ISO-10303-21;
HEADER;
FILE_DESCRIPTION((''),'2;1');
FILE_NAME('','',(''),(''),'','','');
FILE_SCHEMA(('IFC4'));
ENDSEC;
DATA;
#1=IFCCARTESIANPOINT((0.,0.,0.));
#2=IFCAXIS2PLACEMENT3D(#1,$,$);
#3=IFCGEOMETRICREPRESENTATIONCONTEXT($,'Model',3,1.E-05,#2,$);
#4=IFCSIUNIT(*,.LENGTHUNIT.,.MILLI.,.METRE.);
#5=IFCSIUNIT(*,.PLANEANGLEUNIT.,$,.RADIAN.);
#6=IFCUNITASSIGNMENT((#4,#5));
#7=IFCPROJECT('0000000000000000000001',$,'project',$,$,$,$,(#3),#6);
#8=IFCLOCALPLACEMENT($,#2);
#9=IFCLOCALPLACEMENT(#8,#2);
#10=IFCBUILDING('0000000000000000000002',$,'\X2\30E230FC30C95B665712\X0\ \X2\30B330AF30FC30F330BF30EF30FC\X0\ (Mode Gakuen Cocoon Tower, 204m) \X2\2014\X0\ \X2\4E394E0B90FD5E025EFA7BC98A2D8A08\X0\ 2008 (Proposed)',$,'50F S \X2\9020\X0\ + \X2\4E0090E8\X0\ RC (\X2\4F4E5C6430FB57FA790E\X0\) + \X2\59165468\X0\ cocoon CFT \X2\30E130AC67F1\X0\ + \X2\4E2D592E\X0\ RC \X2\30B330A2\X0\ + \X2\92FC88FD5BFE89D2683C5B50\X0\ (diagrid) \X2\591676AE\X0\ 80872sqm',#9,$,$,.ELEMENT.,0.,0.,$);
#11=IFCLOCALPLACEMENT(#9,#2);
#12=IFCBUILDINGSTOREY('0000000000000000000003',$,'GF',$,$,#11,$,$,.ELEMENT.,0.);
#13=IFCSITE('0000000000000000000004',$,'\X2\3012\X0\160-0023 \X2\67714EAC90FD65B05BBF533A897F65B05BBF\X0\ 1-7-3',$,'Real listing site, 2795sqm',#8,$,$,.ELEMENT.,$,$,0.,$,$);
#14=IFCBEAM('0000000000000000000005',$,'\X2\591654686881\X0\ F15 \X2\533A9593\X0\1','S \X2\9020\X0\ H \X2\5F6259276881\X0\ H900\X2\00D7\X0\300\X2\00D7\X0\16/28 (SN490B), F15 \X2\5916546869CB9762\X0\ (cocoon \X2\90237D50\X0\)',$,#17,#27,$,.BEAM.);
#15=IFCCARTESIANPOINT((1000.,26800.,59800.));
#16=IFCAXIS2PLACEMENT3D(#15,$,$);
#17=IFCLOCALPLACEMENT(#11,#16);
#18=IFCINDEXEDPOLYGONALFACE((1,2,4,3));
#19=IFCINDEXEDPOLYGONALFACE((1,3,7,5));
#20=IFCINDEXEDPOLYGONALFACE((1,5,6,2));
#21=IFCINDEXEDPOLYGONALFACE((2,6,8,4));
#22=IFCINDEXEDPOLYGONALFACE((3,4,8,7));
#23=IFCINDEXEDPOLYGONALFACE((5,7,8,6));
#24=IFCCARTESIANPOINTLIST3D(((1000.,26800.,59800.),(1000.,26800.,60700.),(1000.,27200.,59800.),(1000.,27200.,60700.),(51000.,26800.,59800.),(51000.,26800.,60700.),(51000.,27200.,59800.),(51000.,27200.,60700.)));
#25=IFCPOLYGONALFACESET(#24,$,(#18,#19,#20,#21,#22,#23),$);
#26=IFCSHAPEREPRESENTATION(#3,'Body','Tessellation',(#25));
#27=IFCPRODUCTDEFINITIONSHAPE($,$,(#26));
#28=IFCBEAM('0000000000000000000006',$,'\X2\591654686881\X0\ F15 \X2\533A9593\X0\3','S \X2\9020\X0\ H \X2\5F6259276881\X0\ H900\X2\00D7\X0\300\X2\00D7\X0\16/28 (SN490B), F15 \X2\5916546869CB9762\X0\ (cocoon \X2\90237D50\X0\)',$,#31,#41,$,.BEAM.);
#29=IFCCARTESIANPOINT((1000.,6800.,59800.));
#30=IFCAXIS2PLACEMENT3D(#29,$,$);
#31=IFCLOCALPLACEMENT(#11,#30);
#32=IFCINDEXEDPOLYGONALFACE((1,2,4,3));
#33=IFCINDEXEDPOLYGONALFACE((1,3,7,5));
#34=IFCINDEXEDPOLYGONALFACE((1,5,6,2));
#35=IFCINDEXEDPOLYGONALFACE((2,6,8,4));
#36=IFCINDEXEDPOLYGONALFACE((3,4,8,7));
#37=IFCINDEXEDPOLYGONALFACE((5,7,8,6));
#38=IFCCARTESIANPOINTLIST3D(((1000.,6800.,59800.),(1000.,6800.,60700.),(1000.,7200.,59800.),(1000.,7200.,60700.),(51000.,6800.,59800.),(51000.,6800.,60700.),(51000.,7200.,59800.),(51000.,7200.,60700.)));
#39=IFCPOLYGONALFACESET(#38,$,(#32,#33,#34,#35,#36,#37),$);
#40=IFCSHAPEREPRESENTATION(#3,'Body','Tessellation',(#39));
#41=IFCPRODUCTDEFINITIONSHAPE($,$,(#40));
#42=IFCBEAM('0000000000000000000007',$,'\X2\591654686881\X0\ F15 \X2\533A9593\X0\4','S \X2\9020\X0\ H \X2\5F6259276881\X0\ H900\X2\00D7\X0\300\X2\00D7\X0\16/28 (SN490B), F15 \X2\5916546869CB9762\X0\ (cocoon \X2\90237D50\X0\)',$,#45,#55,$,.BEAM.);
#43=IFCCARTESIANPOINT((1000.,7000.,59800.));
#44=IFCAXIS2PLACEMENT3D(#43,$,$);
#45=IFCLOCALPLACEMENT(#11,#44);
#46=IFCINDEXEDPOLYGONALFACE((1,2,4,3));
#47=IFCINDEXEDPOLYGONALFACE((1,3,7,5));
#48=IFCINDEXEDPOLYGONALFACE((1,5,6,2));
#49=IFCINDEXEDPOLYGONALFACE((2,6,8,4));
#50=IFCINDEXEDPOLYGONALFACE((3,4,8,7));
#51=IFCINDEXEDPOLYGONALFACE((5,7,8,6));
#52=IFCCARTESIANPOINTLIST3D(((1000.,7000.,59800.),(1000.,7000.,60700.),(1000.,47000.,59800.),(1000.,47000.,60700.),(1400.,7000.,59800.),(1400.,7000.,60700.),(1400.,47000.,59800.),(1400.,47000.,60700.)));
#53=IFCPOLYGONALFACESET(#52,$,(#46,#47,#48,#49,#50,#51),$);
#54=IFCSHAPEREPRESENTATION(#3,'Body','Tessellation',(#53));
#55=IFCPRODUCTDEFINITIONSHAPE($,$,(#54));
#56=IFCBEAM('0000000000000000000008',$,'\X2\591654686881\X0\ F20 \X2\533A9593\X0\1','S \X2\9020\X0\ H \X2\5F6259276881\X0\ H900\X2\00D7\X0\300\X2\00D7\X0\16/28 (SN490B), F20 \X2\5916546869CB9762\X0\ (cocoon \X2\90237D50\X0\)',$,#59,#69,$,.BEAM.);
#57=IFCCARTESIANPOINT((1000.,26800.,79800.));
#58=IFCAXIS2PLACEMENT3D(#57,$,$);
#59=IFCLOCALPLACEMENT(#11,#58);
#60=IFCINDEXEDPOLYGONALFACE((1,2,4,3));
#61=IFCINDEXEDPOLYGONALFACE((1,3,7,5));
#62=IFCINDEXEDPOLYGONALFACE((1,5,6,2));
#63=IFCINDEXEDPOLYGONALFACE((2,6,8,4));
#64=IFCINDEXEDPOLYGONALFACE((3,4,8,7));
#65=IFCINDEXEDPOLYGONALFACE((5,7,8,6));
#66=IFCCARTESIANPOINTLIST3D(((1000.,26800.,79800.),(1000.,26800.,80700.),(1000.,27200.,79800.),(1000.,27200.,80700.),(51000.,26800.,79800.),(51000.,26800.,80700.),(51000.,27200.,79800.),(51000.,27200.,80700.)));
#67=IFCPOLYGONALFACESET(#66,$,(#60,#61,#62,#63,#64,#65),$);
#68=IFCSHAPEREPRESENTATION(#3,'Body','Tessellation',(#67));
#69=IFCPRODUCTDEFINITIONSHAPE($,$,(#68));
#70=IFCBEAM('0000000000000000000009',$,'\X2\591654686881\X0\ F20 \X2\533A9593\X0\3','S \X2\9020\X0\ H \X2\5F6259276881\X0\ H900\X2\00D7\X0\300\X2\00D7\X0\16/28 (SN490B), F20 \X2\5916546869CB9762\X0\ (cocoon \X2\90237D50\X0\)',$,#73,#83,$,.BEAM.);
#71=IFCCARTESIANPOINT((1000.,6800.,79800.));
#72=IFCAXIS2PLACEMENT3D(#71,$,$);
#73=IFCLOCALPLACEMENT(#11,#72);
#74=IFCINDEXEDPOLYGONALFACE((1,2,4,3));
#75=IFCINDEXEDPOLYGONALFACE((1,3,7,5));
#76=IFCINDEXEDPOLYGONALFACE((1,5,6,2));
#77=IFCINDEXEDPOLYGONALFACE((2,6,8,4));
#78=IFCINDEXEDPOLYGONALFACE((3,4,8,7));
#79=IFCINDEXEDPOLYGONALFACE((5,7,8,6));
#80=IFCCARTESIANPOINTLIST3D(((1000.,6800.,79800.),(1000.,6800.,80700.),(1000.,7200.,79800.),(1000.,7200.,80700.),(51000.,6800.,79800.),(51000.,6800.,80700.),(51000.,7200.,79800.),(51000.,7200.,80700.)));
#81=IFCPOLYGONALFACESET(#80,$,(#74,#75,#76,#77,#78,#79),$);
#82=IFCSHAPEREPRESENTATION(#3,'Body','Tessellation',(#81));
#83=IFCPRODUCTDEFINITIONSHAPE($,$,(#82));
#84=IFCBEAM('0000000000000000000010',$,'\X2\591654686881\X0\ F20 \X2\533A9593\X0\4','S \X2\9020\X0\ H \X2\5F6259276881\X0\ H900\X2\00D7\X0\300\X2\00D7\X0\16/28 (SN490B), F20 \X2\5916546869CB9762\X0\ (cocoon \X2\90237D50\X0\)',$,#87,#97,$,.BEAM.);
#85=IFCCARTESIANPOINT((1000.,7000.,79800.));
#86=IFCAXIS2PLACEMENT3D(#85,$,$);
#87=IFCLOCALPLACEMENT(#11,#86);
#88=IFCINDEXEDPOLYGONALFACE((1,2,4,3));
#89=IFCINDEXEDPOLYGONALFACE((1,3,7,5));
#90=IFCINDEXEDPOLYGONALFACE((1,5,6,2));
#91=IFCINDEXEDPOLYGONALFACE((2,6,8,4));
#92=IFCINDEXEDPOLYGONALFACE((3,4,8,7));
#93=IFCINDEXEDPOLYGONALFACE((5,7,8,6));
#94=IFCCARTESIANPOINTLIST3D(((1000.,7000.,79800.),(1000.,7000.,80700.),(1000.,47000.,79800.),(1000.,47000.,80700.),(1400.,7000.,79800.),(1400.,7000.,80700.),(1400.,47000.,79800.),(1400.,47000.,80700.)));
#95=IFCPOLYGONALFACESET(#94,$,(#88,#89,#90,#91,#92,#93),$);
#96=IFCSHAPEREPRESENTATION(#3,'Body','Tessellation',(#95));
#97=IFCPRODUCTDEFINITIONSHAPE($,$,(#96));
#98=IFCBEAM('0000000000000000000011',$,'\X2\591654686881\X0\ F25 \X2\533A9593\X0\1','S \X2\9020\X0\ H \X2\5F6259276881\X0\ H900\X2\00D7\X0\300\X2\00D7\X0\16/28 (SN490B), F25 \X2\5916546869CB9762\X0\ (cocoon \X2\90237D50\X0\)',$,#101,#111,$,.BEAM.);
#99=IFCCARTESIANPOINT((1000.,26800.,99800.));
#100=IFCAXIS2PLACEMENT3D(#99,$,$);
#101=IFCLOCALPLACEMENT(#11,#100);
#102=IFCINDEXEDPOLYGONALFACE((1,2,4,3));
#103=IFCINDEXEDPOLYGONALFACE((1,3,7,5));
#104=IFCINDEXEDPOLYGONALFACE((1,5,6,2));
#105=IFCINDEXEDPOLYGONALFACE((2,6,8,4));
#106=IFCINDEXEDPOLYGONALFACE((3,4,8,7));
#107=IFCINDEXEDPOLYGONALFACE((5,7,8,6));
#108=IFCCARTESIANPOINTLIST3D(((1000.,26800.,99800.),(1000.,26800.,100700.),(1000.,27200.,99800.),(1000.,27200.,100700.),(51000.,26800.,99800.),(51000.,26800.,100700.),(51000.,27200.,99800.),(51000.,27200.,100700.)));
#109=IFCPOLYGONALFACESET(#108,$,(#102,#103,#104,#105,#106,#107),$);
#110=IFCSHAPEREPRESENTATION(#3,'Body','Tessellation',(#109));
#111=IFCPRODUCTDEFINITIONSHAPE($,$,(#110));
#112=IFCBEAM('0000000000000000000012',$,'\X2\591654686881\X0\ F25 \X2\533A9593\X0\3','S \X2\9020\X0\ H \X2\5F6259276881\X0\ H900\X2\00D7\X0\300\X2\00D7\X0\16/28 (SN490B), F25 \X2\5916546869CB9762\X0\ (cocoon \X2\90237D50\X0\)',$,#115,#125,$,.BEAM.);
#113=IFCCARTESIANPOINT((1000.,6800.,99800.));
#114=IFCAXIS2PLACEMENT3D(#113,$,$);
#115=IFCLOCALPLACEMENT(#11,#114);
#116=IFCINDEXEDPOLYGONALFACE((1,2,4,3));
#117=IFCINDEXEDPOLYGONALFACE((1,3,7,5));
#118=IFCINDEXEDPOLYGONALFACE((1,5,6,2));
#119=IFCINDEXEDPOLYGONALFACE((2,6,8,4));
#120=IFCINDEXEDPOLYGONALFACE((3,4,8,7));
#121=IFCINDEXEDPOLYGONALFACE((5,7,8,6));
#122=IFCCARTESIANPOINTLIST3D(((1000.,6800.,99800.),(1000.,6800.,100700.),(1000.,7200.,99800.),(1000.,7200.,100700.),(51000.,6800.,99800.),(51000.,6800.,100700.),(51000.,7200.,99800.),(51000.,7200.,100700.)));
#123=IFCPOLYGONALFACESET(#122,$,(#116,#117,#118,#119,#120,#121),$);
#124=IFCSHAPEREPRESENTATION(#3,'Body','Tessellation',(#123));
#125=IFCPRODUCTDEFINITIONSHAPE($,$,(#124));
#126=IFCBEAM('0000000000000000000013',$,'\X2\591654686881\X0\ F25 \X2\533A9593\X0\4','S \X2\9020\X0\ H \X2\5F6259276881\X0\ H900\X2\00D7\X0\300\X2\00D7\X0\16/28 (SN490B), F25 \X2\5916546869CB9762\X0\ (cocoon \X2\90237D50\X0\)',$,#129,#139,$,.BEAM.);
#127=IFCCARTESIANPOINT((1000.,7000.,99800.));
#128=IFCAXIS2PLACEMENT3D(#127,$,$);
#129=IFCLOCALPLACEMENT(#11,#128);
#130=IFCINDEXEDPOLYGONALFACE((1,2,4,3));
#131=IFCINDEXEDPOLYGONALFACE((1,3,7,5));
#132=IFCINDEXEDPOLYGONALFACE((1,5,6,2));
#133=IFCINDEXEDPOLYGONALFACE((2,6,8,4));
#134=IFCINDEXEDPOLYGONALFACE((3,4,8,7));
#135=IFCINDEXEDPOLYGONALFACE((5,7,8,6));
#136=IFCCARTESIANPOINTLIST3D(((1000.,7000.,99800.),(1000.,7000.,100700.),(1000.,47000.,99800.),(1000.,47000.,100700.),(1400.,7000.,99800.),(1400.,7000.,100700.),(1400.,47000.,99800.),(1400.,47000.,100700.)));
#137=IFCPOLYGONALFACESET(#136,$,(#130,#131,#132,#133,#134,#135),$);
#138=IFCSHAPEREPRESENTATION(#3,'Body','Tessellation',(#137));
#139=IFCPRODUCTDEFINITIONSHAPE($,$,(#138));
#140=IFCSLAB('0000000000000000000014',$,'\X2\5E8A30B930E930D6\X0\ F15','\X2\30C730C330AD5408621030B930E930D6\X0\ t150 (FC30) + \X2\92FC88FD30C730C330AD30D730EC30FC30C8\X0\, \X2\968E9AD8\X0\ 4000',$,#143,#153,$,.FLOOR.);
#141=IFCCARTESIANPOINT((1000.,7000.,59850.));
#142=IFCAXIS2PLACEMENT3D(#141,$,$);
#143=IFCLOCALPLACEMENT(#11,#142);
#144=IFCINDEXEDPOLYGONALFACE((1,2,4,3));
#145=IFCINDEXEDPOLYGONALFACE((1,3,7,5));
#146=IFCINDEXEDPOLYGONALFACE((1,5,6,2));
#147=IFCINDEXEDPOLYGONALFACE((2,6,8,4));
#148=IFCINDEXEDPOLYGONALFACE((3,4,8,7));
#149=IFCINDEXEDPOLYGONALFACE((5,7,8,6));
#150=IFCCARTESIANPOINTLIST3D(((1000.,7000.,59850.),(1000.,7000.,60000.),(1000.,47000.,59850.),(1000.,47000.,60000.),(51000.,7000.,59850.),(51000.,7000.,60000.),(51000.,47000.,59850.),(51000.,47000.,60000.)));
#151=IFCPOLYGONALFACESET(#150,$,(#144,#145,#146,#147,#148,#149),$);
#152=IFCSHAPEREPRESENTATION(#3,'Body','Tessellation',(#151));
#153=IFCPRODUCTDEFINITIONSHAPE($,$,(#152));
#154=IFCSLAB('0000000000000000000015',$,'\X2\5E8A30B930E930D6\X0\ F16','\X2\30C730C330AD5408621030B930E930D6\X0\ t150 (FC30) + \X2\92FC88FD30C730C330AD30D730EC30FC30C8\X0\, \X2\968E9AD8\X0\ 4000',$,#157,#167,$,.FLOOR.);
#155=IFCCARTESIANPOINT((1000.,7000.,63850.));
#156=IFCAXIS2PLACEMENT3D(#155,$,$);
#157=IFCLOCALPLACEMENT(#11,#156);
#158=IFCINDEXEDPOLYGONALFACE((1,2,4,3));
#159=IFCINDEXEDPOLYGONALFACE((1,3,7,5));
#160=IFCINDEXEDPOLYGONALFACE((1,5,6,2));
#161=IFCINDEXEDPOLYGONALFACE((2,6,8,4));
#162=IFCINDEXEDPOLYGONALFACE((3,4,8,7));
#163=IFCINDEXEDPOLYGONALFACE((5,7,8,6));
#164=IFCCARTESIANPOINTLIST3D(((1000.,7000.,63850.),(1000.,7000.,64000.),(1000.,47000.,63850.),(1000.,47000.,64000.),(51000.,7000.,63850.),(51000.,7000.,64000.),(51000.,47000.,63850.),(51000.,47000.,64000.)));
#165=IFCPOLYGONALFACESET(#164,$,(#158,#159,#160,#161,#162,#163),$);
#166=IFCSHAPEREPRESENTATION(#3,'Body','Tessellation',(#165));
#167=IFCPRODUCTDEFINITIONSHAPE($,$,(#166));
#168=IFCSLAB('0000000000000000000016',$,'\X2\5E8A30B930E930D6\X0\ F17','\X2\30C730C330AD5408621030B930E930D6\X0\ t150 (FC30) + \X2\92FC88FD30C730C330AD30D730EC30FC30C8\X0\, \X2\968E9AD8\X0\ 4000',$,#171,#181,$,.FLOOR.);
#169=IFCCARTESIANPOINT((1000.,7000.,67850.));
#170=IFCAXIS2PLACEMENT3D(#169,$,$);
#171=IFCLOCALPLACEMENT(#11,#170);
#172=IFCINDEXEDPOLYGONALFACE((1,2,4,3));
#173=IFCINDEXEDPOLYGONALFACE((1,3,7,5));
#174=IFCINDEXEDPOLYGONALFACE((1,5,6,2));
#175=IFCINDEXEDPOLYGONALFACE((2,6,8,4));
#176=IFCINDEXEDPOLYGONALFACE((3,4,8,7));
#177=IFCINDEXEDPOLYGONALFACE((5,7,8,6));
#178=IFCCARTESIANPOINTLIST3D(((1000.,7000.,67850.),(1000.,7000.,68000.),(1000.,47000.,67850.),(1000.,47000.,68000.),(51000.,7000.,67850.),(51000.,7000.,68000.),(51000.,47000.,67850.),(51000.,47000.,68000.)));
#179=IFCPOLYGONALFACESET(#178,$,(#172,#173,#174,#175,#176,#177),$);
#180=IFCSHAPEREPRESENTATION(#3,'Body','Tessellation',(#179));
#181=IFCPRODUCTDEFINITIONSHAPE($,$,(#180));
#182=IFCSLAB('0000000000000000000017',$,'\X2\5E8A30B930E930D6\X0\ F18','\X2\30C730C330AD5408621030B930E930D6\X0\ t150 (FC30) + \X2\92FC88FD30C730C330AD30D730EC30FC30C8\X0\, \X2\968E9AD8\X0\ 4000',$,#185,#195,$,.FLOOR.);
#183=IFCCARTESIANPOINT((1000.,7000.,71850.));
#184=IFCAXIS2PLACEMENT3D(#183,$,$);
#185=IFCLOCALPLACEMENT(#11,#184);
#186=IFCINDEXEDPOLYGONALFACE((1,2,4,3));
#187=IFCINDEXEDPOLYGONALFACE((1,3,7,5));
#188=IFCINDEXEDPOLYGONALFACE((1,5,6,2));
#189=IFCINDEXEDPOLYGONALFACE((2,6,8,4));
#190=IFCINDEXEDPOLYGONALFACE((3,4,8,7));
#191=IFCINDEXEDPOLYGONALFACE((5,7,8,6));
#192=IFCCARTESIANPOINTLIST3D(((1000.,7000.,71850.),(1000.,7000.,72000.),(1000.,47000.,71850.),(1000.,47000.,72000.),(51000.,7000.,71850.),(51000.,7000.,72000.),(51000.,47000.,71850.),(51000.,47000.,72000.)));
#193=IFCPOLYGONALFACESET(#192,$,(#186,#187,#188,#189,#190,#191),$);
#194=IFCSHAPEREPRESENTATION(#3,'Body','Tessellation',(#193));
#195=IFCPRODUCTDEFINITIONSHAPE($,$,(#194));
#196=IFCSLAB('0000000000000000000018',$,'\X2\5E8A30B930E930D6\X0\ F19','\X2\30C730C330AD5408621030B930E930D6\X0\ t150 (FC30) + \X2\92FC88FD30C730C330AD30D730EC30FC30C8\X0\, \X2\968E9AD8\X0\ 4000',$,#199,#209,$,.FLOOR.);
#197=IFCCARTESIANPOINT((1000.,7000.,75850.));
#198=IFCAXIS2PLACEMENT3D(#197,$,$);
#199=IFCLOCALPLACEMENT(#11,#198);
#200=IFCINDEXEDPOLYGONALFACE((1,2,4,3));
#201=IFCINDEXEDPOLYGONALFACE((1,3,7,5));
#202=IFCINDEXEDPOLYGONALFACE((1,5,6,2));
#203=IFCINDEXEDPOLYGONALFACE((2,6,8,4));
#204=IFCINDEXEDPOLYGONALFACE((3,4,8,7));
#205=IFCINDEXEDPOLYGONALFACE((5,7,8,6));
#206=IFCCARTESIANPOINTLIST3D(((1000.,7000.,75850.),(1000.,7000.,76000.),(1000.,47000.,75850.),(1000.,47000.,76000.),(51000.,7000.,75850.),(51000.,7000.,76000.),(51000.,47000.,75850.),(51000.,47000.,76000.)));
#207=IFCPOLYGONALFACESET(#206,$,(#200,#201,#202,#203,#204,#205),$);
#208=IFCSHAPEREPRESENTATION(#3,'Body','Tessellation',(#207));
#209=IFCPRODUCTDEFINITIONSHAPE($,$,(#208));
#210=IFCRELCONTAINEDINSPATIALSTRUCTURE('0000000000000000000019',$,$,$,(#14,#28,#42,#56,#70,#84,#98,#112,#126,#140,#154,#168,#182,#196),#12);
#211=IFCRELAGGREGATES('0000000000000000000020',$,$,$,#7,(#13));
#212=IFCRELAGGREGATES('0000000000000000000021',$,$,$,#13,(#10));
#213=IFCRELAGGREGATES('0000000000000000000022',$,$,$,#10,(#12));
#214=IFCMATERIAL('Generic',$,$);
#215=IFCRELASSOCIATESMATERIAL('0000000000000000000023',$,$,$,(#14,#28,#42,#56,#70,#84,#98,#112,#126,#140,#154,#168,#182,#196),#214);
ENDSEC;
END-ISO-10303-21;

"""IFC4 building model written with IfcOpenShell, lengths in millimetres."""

from ifc_helpers import new_model, si_unit, frame, frame_2d, origin, place, context, project, spatial, rectangle, extrude, material, element, save


model = new_model("IFC4")

# Units and contexts
model_context = context("Model", 3, precision=1e-05, world=origin())
ifc_project = project(units=[si_unit("LENGTHUNIT", "METRE", prefix="MILLI"), si_unit("PLANEANGLEUNIT", "RADIAN")], contexts=[model_context])

# Site, building, storey
site_placement = place(None, origin())
site = spatial("IfcSite", under=ifc_project, at=site_placement, Name="〒160-0023 東京都新宿区西新宿 1-7-3", ObjectType="Real listing site, 2795sqm", CompositionType="ELEMENT", RefElevation=0.0)
building_placement = place(site_placement, origin())
building = spatial("IfcBuilding", under=site, at=building_placement, Name="モード学園 コクーンタワー (Mode Gakuen Cocoon Tower, 204m) — 丹下都市建築設計 2008 (Proposed)", ObjectType="50F S 造 + 一部 RC (低層・基礎) + 外周 cocoon CFT メガ柱 + 中央 RC コア + 鋼製対角格子 (diagrid) 外皮 80872sqm", CompositionType="ELEMENT", ElevationOfRefHeight=0.0, ElevationOfTerrain=0.0)
storey_placement = place(building_placement, origin())
storey = spatial("IfcBuildingStorey", under=building, at=storey_placement, Name="GF", CompositionType="ELEMENT", Elevation=0.0)

# Beams
ifc_material_1 = material(Name="Generic")
beam_1_placement = place(storey_placement, frame((1000.0, 26800.0, 59800.0)))
element("IfcBeam", 1, at=beam_1_placement, inside=storey, material=ifc_material_1, Name="外周梁 F15 区間1", Description="S 造 H 形大梁 H900×300×16/28 (SN490B), F15 外周構面 (cocoon 連結)", PredefinedType="BEAM", context=model_context, shape_type="SweptSolid", body=[
    extrude(rectangle(XDim=50000.0, YDim=400.0, at=frame_2d((25000.0, 200.0))), frame((1000.0, 26800.0, 59800.0)), (0.0, 0.0, 1.0), 900.0),
])
beam_2_placement = place(storey_placement, frame((1000.0, 6800.0, 59800.0)))
element("IfcBeam", 2, at=beam_2_placement, inside=storey, material=ifc_material_1, Name="外周梁 F15 区間3", Description="S 造 H 形大梁 H900×300×16/28 (SN490B), F15 外周構面 (cocoon 連結)", PredefinedType="BEAM", context=model_context, shape_type="SweptSolid", body=[
    extrude(rectangle(XDim=50000.0, YDim=400.0, at=frame_2d((25000.0, 200.0))), frame((1000.0, 6800.0, 59800.0)), (0.0, 0.0, 1.0), 900.0),
])
beam_3_placement = place(storey_placement, frame((1000.0, 7000.0, 59800.0)))
element("IfcBeam", 3, at=beam_3_placement, inside=storey, material=ifc_material_1, Name="外周梁 F15 区間4", Description="S 造 H 形大梁 H900×300×16/28 (SN490B), F15 外周構面 (cocoon 連結)", PredefinedType="BEAM", context=model_context, shape_type="SweptSolid", body=[
    extrude(rectangle(XDim=400.0, YDim=40000.0, at=frame_2d((200.0, 20000.0))), frame((1000.0, 7000.0, 59800.0)), (0.0, 0.0, 1.0), 900.0),
])
beam_4_placement = place(storey_placement, frame((1000.0, 26800.0, 79800.0)))
element("IfcBeam", 4, at=beam_4_placement, inside=storey, material=ifc_material_1, Name="外周梁 F20 区間1", Description="S 造 H 形大梁 H900×300×16/28 (SN490B), F20 外周構面 (cocoon 連結)", PredefinedType="BEAM", context=model_context, shape_type="SweptSolid", body=[
    extrude(rectangle(XDim=50000.0, YDim=400.0, at=frame_2d((25000.0, 200.0))), frame((1000.0, 26800.0, 79800.0)), (0.0, 0.0, 1.0), 900.0),
])
beam_5_placement = place(storey_placement, frame((1000.0, 6800.0, 79800.0)))
element("IfcBeam", 5, at=beam_5_placement, inside=storey, material=ifc_material_1, Name="外周梁 F20 区間3", Description="S 造 H 形大梁 H900×300×16/28 (SN490B), F20 外周構面 (cocoon 連結)", PredefinedType="BEAM", context=model_context, shape_type="SweptSolid", body=[
    extrude(rectangle(XDim=50000.0, YDim=400.0, at=frame_2d((25000.0, 200.0))), frame((1000.0, 6800.0, 79800.0)), (0.0, 0.0, 1.0), 900.0),
])
beam_6_placement = place(storey_placement, frame((1000.0, 7000.0, 79800.0)))
element("IfcBeam", 6, at=beam_6_placement, inside=storey, material=ifc_material_1, Name="外周梁 F20 区間4", Description="S 造 H 形大梁 H900×300×16/28 (SN490B), F20 外周構面 (cocoon 連結)", PredefinedType="BEAM", context=model_context, shape_type="SweptSolid", body=[
    extrude(rectangle(XDim=400.0, YDim=40000.0, at=frame_2d((200.0, 20000.0))), frame((1000.0, 7000.0, 79800.0)), (0.0, 0.0, 1.0), 900.0),
])
beam_7_placement = place(storey_placement, frame((1000.0, 26800.0, 99800.0)))
element("IfcBeam", 7, at=beam_7_placement, inside=storey, material=ifc_material_1, Name="外周梁 F25 区間1", Description="S 造 H 形大梁 H900×300×16/28 (SN490B), F25 外周構面 (cocoon 連結)", PredefinedType="BEAM", context=model_context, shape_type="SweptSolid", body=[
    extrude(rectangle(XDim=50000.0, YDim=400.0, at=frame_2d((25000.0, 200.0))), frame((1000.0, 26800.0, 99800.0)), (0.0, 0.0, 1.0), 900.0),
])
beam_8_placement = place(storey_placement, frame((1000.0, 6800.0, 99800.0)))
element("IfcBeam", 8, at=beam_8_placement, inside=storey, material=ifc_material_1, Name="外周梁 F25 区間3", Description="S 造 H 形大梁 H900×300×16/28 (SN490B), F25 外周構面 (cocoon 連結)", PredefinedType="BEAM", context=model_context, shape_type="SweptSolid", body=[
    extrude(rectangle(XDim=50000.0, YDim=400.0, at=frame_2d((25000.0, 200.0))), frame((1000.0, 6800.0, 99800.0)), (0.0, 0.0, 1.0), 900.0),
])
beam_9_placement = place(storey_placement, frame((1000.0, 7000.0, 99800.0)))
element("IfcBeam", 9, at=beam_9_placement, inside=storey, material=ifc_material_1, Name="外周梁 F25 区間4", Description="S 造 H 形大梁 H900×300×16/28 (SN490B), F25 外周構面 (cocoon 連結)", PredefinedType="BEAM", context=model_context, shape_type="SweptSolid", body=[
    extrude(rectangle(XDim=400.0, YDim=40000.0, at=frame_2d((200.0, 20000.0))), frame((1000.0, 7000.0, 99800.0)), (0.0, 0.0, 1.0), 900.0),
])

# Slabs
slab_1_placement = place(storey_placement, frame((1000.0, 7000.0, 59850.0)))
element("IfcSlab", 10, at=slab_1_placement, inside=storey, material=ifc_material_1, Name="床スラブ F15", Description="デッキ合成スラブ t150 (FC30) + 鋼製デッキプレート, 階高 4000", PredefinedType="FLOOR", context=model_context, shape_type="SweptSolid", body=[
    extrude(rectangle(XDim=50000.0, YDim=40000.0, at=frame_2d((25000.0, 20000.0))), frame((1000.0, 7000.0, 59850.0)), (0.0, 0.0, 1.0), 150.0),
])
slab_2_placement = place(storey_placement, frame((1000.0, 7000.0, 63850.0)))
element("IfcSlab", 11, at=slab_2_placement, inside=storey, material=ifc_material_1, Name="床スラブ F16", Description="デッキ合成スラブ t150 (FC30) + 鋼製デッキプレート, 階高 4000", PredefinedType="FLOOR", context=model_context, shape_type="SweptSolid", body=[
    extrude(rectangle(XDim=50000.0, YDim=40000.0, at=frame_2d((25000.0, 20000.0))), frame((1000.0, 7000.0, 63850.0)), (0.0, 0.0, 1.0), 150.0),
])
slab_3_placement = place(storey_placement, frame((1000.0, 7000.0, 67850.0)))
element("IfcSlab", 12, at=slab_3_placement, inside=storey, material=ifc_material_1, Name="床スラブ F17", Description="デッキ合成スラブ t150 (FC30) + 鋼製デッキプレート, 階高 4000", PredefinedType="FLOOR", context=model_context, shape_type="SweptSolid", body=[
    extrude(rectangle(XDim=50000.0, YDim=40000.0, at=frame_2d((25000.0, 20000.0))), frame((1000.0, 7000.0, 67850.0)), (0.0, 0.0, 1.0), 150.0),
])
slab_4_placement = place(storey_placement, frame((1000.0, 7000.0, 71850.0)))
element("IfcSlab", 13, at=slab_4_placement, inside=storey, material=ifc_material_1, Name="床スラブ F18", Description="デッキ合成スラブ t150 (FC30) + 鋼製デッキプレート, 階高 4000", PredefinedType="FLOOR", context=model_context, shape_type="SweptSolid", body=[
    extrude(rectangle(XDim=50000.0, YDim=40000.0, at=frame_2d((25000.0, 20000.0))), frame((1000.0, 7000.0, 71850.0)), (0.0, 0.0, 1.0), 150.0),
])
slab_5_placement = place(storey_placement, frame((1000.0, 7000.0, 75850.0)))
element("IfcSlab", 14, at=slab_5_placement, inside=storey, material=ifc_material_1, Name="床スラブ F19", Description="デッキ合成スラブ t150 (FC30) + 鋼製デッキプレート, 階高 4000", PredefinedType="FLOOR", context=model_context, shape_type="SweptSolid", body=[
    extrude(rectangle(XDim=50000.0, YDim=40000.0, at=frame_2d((25000.0, 20000.0))), frame((1000.0, 7000.0, 75850.0)), (0.0, 0.0, 1.0), 150.0),
])

save(model, "model.ifc")
